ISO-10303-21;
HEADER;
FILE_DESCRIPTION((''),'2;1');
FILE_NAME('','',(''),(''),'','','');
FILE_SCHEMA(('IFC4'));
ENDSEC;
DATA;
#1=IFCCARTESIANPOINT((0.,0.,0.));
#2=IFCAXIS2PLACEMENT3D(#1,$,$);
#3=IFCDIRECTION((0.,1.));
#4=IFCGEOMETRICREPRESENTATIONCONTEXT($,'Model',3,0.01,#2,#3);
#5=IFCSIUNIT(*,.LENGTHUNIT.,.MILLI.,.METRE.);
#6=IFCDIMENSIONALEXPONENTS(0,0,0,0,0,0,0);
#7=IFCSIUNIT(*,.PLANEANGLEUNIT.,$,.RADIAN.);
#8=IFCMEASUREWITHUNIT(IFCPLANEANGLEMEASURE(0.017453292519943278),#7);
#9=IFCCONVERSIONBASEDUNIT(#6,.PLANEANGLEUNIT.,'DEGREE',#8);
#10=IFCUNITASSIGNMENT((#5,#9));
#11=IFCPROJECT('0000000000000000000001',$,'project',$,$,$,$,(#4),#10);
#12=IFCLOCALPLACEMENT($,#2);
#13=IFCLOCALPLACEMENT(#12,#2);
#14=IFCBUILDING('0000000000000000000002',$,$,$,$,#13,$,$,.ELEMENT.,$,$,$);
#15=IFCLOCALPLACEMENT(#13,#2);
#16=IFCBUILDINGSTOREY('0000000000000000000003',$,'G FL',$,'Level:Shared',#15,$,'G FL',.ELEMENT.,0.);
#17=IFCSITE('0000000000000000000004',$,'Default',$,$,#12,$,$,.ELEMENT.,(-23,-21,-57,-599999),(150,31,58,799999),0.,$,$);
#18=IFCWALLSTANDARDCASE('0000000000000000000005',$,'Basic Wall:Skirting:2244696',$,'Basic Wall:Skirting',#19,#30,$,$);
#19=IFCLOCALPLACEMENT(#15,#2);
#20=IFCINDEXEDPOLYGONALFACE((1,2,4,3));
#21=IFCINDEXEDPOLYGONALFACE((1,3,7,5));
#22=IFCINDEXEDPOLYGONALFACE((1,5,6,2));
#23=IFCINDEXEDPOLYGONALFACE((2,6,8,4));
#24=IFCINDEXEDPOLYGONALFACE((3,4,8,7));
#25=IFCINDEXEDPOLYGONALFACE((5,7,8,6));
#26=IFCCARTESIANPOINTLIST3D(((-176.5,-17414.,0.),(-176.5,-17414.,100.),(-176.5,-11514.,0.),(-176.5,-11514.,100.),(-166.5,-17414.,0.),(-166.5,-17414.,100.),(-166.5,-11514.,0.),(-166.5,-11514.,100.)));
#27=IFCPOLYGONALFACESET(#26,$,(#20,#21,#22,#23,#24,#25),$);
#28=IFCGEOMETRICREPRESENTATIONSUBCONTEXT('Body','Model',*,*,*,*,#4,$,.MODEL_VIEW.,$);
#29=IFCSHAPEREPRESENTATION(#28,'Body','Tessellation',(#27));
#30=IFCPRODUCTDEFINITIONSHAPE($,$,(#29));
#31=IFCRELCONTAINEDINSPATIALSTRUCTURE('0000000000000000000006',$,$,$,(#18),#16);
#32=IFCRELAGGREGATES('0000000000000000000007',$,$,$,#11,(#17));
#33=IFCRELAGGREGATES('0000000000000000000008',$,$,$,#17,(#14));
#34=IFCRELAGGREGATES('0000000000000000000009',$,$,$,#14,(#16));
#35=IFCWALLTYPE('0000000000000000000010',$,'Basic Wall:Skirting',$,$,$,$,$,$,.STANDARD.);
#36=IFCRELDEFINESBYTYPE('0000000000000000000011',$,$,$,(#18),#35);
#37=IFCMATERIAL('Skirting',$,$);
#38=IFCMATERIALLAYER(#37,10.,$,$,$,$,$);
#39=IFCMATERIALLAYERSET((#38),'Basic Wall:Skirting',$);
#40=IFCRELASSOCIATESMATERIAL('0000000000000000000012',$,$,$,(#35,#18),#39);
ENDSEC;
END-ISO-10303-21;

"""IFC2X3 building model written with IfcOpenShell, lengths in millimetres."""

from ifc_helpers import new_model, entity, si_unit, converted_unit, direction, frame, frame_2d, origin, place, context, subcontext, project, spatial, rectangle, extrude, material, layer, layer_set, layer_usage, type_object, element, save


model = new_model("IFC2X3")

# Units and contexts
model_context = context("Model", 3, precision=0.01, world=origin(), true_north=direction((0.0, 1.0)))
body_context = subcontext(model_context, "Body", "Model", "MODEL_VIEW")
ifc_project = project(units=[si_unit("LENGTHUNIT", "METRE", prefix="MILLI"), converted_unit("PLANEANGLEUNIT", "DEGREE", entity("IfcPlaneAngleMeasure", 0.017453292519943278), si_unit("PLANEANGLEUNIT", "RADIAN"), dimensions=[0, 0, 0, 0, 0, 0, 0])], contexts=[model_context])

# Site, building, storey
site_placement = place(None, origin())
site = spatial("IfcSite", under=ifc_project, at=site_placement, Name="Default", CompositionType="ELEMENT", RefLatitude=(-23, -21, -57, -599999), RefLongitude=(150, 31, 58, 799999), RefElevation=0.0)
building_placement = place(site_placement, origin())
building = spatial("IfcBuilding", under=site, at=building_placement, CompositionType="ELEMENT")
storey_placement = place(building_placement, origin())
storey = spatial("IfcBuildingStorey", under=building, at=storey_placement, Name="G FL", ObjectType="Level:Shared", LongName="G FL", CompositionType="ELEMENT", Elevation=0.0)

# Wall
ifc_material_1 = material(Name="Skirting")
ifc_layer_1 = layer(ifc_material_1, 10.0)
ifc_layer_set_1 = layer_set([ifc_layer_1], Name="Basic Wall:Skirting")
ifc_layer_usage_1 = layer_usage(ifc_layer_set_1, "AXIS2", "NEGATIVE", 5.0)
wall_type_1 = type_object("IfcWallType", Name="Basic Wall:Skirting", PredefinedType="STANDARD", material=ifc_layer_set_1)
wall_1_placement = place(storey_placement, frame((-171.5, -17414.0, 0.0), z_axis=(0.0, 0.0, 1.0), x_axis=(0.0, 1.0, 0.0)))
element("IfcWallStandardCase", 1, at=wall_1_placement, inside=storey, type_object=wall_type_1, material=ifc_layer_usage_1, Name="Basic Wall:Skirting:2244696", ObjectType="Basic Wall:Skirting", context=body_context, shape_type="SweptSolid", body=[
    extrude(rectangle(XDim=5900.0, YDim=10.0, at=frame_2d((2950.0, 0.0), x_axis=(-1.0, 0.0))), origin(), (0.0, 0.0, 1.0), 100.0),
])

save(model, "model.ifc")
